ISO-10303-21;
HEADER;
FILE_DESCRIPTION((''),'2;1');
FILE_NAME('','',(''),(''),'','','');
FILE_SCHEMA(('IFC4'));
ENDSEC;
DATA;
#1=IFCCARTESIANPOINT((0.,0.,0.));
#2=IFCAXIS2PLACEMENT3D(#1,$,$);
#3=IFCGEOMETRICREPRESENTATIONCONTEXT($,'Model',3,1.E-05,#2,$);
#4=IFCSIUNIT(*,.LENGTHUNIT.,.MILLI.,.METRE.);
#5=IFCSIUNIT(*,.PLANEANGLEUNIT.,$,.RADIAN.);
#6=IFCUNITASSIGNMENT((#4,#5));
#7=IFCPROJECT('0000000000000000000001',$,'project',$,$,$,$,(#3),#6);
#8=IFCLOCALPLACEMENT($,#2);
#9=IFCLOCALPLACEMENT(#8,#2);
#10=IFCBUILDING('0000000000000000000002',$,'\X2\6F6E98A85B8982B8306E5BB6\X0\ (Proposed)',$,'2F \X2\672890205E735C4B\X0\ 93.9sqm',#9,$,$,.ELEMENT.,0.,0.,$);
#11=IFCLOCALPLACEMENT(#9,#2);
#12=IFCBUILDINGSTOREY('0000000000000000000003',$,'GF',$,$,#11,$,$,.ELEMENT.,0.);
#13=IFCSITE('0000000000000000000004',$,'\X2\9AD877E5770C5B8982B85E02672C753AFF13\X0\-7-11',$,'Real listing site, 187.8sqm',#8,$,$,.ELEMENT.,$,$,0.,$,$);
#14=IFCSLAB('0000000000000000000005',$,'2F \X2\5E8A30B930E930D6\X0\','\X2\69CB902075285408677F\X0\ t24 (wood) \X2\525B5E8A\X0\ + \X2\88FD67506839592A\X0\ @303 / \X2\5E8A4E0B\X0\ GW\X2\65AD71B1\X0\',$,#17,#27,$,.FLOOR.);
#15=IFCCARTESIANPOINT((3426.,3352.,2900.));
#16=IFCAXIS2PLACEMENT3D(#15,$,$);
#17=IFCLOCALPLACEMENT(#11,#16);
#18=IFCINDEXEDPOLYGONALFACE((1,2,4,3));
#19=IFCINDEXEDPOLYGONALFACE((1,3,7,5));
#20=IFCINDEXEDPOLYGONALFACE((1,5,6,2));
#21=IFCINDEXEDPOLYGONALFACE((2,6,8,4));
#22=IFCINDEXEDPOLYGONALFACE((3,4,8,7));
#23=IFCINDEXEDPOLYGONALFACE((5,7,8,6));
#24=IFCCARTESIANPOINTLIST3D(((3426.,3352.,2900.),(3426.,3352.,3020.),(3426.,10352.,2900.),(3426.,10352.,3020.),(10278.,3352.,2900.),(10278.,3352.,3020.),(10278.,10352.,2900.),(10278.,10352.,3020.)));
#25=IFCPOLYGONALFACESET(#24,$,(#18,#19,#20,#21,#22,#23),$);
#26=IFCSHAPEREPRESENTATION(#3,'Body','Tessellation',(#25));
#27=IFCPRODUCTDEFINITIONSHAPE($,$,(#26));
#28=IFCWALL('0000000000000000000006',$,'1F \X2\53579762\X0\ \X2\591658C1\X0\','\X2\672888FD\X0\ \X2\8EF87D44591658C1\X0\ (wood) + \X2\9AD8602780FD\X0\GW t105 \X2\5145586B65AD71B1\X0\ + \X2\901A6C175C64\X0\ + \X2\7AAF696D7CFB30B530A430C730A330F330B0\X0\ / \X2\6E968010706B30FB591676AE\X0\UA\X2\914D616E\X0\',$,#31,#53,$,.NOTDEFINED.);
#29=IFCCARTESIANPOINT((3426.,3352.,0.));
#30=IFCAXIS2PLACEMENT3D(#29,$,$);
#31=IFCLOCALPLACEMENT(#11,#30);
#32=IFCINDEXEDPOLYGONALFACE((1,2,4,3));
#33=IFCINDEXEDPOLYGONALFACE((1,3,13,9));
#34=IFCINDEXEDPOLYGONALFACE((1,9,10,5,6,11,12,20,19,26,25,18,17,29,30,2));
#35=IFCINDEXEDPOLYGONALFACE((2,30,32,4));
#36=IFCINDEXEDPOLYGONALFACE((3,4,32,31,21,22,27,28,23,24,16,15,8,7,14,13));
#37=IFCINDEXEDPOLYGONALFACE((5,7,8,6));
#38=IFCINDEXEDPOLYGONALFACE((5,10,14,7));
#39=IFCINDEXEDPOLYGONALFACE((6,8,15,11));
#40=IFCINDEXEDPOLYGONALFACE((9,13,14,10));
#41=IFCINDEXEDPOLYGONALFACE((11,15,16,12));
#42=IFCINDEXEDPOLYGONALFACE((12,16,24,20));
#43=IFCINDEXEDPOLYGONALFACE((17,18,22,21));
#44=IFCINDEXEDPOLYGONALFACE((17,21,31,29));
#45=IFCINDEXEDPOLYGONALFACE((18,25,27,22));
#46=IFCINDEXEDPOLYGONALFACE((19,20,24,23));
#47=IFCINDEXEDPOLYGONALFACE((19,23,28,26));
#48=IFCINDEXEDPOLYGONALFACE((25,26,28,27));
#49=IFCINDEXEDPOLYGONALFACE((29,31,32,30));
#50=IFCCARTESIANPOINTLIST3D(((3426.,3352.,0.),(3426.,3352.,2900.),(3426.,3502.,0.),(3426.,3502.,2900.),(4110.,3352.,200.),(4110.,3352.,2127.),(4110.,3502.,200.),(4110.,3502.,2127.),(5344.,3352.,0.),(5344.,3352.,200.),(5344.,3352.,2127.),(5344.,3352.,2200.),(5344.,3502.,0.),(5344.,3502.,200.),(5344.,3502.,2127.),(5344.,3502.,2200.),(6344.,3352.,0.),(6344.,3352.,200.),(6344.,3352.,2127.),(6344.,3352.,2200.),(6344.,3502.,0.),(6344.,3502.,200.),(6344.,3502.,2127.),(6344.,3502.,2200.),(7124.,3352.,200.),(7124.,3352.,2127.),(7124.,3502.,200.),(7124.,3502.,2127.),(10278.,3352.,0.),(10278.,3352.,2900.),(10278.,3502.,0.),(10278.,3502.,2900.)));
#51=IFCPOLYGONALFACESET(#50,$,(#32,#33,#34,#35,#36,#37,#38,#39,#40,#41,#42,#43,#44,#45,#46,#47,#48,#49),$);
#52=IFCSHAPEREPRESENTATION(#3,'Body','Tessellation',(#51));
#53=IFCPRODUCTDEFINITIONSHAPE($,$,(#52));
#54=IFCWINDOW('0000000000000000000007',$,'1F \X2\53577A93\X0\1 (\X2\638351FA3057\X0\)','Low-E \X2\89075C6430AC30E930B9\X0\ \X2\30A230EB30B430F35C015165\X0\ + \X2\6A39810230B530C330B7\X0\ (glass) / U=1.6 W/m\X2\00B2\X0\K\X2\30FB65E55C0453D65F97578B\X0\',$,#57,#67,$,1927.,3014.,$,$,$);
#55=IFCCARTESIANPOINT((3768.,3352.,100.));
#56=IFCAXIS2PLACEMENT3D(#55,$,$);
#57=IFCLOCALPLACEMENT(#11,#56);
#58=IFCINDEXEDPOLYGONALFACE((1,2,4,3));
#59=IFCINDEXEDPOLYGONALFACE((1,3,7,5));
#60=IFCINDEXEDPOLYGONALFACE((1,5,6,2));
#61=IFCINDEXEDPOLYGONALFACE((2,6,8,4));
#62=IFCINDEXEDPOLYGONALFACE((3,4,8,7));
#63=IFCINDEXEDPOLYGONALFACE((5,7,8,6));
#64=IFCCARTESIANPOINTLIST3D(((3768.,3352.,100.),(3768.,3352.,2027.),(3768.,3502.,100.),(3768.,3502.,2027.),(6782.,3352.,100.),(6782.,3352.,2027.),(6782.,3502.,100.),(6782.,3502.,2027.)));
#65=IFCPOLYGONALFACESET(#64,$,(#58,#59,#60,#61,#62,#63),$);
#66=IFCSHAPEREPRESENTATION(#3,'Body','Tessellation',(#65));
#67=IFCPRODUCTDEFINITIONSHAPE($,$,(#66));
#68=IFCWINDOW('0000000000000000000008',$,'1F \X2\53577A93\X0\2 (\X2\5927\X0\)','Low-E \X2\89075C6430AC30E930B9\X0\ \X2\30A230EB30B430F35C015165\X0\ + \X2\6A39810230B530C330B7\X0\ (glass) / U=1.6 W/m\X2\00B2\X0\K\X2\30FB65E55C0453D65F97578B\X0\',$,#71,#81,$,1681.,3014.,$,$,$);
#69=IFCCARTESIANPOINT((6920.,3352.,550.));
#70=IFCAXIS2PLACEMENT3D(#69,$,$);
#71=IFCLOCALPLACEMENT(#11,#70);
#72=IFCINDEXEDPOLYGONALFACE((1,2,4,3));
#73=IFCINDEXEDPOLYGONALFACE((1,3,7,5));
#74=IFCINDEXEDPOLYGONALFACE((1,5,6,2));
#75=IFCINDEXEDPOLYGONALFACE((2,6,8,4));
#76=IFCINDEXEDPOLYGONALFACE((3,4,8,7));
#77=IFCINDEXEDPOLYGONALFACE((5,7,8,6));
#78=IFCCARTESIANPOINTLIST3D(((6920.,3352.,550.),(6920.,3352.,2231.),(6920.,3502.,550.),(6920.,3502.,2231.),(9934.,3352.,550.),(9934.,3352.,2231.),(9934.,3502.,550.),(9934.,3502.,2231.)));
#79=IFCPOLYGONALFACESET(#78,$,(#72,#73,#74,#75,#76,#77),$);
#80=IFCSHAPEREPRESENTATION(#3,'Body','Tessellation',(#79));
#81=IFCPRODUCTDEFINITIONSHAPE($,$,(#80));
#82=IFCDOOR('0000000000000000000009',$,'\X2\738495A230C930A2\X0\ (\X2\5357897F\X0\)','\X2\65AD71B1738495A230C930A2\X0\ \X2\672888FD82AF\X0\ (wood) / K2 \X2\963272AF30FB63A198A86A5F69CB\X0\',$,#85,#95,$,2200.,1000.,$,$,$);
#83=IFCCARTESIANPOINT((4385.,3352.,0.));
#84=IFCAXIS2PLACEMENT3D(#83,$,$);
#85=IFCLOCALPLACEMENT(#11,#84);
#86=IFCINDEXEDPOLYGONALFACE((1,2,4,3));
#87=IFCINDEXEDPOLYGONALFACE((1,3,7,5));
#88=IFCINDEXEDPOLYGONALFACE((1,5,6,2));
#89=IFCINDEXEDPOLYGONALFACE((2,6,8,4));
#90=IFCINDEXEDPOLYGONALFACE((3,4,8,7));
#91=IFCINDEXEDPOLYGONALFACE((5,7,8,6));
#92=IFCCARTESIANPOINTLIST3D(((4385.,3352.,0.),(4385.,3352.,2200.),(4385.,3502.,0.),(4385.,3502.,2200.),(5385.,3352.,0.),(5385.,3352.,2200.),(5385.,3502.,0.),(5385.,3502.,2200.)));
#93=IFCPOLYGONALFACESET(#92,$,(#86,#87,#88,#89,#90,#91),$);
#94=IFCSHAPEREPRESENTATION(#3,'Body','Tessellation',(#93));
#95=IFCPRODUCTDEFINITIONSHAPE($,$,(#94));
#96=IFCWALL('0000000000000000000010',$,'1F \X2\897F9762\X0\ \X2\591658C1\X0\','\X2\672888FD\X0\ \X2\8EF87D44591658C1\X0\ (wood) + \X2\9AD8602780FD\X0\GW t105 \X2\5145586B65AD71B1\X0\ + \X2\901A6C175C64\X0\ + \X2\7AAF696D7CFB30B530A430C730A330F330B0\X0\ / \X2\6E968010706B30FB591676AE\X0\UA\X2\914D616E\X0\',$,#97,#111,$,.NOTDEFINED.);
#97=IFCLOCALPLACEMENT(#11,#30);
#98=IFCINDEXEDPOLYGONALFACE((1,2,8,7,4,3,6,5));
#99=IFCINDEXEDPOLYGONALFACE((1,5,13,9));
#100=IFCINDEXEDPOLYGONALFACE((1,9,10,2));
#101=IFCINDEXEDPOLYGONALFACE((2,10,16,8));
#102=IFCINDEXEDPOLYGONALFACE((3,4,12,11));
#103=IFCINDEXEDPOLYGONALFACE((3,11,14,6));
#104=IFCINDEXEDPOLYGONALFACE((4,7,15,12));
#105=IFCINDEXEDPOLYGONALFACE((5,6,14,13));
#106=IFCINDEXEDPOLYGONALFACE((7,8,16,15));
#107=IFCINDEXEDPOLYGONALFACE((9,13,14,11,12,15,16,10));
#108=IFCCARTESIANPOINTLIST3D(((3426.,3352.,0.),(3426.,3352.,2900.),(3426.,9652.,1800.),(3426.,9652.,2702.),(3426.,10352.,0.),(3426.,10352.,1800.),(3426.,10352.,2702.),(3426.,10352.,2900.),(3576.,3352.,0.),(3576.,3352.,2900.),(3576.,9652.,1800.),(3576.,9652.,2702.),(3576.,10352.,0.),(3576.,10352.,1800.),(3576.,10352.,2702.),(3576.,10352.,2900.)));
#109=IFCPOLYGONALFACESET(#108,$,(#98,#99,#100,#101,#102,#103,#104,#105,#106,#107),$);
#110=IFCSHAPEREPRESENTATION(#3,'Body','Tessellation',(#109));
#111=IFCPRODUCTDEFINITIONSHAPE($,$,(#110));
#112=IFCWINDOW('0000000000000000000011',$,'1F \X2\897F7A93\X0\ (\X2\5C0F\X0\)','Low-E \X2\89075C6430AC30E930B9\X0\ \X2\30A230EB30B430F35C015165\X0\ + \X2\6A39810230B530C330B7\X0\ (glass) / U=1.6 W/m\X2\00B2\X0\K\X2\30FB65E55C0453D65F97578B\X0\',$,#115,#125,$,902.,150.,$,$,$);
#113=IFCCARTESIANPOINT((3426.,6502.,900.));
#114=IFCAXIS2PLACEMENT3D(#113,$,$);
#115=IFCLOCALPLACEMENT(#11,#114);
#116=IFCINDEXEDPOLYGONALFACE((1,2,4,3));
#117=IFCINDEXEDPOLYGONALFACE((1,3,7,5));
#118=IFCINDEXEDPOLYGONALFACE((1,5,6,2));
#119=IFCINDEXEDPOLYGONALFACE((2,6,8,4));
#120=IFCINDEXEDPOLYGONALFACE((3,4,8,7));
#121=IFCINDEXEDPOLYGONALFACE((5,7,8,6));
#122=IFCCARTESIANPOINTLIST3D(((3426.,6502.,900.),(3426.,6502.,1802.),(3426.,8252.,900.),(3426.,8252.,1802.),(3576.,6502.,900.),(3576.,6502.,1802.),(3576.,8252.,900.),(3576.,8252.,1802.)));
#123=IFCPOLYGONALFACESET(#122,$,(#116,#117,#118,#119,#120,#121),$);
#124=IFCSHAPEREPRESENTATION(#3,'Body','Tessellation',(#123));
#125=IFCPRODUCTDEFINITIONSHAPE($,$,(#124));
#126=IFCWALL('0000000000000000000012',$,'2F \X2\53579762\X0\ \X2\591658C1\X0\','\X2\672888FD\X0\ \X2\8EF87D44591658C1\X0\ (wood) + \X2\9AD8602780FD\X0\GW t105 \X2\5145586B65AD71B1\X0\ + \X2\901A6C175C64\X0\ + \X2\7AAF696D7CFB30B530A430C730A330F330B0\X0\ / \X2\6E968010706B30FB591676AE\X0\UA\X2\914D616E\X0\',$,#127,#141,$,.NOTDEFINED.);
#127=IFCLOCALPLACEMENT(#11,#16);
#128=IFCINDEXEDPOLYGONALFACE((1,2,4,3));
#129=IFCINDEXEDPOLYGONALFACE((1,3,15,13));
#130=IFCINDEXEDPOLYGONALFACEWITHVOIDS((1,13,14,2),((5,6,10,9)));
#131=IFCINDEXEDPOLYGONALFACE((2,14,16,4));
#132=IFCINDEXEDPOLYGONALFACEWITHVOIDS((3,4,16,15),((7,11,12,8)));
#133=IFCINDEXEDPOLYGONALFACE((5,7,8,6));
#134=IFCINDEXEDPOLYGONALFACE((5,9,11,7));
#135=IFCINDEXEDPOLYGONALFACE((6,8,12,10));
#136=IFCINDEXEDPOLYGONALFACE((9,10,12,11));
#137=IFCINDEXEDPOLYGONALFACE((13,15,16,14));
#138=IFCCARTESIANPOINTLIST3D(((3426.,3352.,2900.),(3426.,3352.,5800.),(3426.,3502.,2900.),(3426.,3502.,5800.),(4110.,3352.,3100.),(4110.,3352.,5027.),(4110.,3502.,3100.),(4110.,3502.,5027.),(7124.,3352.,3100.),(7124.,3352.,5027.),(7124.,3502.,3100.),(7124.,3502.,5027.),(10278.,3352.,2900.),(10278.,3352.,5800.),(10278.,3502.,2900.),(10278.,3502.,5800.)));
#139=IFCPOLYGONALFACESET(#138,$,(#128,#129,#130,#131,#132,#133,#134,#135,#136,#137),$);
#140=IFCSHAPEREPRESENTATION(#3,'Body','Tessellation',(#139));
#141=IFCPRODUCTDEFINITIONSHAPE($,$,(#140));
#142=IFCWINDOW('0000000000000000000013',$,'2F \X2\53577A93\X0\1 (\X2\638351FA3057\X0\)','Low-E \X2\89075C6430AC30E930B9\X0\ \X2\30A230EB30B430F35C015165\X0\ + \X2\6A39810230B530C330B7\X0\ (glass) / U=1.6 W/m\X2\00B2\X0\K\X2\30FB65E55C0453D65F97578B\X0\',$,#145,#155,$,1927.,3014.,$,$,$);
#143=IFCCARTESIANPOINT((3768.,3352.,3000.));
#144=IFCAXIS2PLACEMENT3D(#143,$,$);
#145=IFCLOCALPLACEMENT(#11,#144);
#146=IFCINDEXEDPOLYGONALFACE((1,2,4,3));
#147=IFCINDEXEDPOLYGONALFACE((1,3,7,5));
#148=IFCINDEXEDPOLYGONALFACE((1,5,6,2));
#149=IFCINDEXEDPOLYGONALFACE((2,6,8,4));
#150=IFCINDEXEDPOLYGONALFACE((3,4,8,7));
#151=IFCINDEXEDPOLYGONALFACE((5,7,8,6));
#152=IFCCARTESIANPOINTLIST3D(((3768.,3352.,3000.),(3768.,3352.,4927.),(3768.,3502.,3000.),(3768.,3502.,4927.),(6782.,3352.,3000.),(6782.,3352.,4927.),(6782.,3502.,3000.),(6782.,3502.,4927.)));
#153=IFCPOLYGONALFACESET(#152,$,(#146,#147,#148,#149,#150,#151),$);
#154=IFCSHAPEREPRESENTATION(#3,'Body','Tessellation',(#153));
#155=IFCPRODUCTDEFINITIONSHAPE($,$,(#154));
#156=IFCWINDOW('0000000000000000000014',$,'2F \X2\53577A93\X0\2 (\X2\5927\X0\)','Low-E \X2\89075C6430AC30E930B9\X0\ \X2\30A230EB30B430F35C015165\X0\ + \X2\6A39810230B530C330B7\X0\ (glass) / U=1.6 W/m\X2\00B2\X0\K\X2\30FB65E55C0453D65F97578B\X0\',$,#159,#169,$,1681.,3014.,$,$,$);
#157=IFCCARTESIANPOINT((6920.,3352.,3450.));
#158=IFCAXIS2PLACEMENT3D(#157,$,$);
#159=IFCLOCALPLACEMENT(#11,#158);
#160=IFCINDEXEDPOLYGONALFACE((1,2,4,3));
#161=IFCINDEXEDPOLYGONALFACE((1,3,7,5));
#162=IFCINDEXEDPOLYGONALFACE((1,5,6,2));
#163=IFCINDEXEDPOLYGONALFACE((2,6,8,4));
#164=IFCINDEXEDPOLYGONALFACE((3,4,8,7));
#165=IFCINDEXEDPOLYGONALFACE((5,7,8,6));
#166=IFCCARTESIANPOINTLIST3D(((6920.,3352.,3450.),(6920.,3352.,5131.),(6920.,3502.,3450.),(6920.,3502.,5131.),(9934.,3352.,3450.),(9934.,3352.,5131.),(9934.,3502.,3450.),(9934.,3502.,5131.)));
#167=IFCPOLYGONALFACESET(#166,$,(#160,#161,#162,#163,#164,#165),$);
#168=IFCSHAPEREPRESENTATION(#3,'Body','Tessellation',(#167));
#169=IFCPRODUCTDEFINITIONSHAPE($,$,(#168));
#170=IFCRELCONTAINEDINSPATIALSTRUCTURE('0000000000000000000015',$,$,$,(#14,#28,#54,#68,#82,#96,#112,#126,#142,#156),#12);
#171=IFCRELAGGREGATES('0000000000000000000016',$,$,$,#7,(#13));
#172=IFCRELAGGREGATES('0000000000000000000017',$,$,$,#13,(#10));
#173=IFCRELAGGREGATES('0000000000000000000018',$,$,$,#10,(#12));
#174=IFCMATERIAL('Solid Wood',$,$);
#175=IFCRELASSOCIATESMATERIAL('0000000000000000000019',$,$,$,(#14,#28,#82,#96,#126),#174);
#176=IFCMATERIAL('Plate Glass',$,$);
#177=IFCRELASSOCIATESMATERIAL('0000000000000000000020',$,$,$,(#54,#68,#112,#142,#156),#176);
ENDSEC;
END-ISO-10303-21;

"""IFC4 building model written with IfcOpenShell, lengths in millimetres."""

from ifc_helpers import new_model, si_unit, frame, frame_2d, origin, place, context, project, spatial, rectangle, extrude, material, element, fill, save


model = new_model("IFC4")

# Units and contexts
model_context = context("Model", 3, precision=1e-05, world=origin())
ifc_project = project(units=[si_unit("LENGTHUNIT", "METRE", prefix="MILLI"), si_unit("PLANEANGLEUNIT", "RADIAN")], contexts=[model_context])

# Site, building, storey
site_placement = place(None, origin())
site = spatial("IfcSite", under=ifc_project, at=site_placement, Name="高知県安芸市本町３-7-11", ObjectType="Real listing site, 187.8sqm", CompositionType="ELEMENT", RefElevation=0.0)
building_placement = place(site_placement, origin())
building = spatial("IfcBuilding", under=site, at=building_placement, Name="潮風安芸の家 (Proposed)", ObjectType="2F 木造平屋 93.9sqm", CompositionType="ELEMENT", ElevationOfRefHeight=0.0, ElevationOfTerrain=0.0)
storey_placement = place(building_placement, origin())
storey = spatial("IfcBuildingStorey", under=building, at=storey_placement, Name="GF", CompositionType="ELEMENT", Elevation=0.0)

# Slab
ifc_material_1 = material(Name="Solid Wood")
slab_1_placement = place(storey_placement, frame((3426.0, 3352.0, 2900.0)))
element("IfcSlab", 1, at=slab_1_placement, inside=storey, material=ifc_material_1, Name="2F 床スラブ", Description="構造用合板 t24 (wood) 剛床 + 製材根太 @303 / 床下 GW断熱", PredefinedType="FLOOR", context=model_context, shape_type="SweptSolid", body=[
    extrude(rectangle(XDim=6852.0, YDim=7000.0, at=frame_2d((3426.0, 3500.0))), frame((3426.0, 3352.0, 2900.0)), (0.0, 0.0, 1.0), 120.0),
])

# Wall, openings, windows, door
wall_1_placement = place(storey_placement, frame((3426.0, 3352.0, 0.0)))
wall_1 = element("IfcWall", 2, at=wall_1_placement, inside=storey, material=ifc_material_1, Name="1F 南面 外壁", Description="木製 軸組外壁 (wood) + 高性能GW t105 充填断熱 + 通気層 + 窯業系サイディング / 準耐火・外皮UA配慮", PredefinedType="NOTDEFINED", context=model_context, shape_type="SweptSolid", body=[
    extrude(rectangle(XDim=6852.0, YDim=150.0, at=frame_2d((3426.0, 75.0))), frame((3426.0, 3352.0, 0.0)), (0.0, 0.0, 1.0), 2900.0),
])
opening_1_placement = place(storey_placement, frame((3768.0, 3352.0, 100.0)))
opening_1 = element("IfcOpeningElement", 3, at=opening_1_placement, cuts=wall_1, PredefinedType="NOTDEFINED", context=model_context, shape_type="SweptSolid", body=[
    extrude(rectangle(XDim=3014.0, YDim=150.0, at=frame_2d((1507.0, 75.0))), frame((3768.0, 3352.0, 100.0)), (0.0, 0.0, 1.0), 1927.0),
])
opening_2_placement = place(storey_placement, frame((6920.0, 3352.0, 550.0)))
opening_2 = element("IfcOpeningElement", 4, at=opening_2_placement, cuts=wall_1, PredefinedType="NOTDEFINED", context=model_context, shape_type="SweptSolid", body=[
    extrude(rectangle(XDim=3014.0, YDim=150.0, at=frame_2d((1507.0, 75.0))), frame((6920.0, 3352.0, 550.0)), (0.0, 0.0, 1.0), 1681.0),
])
opening_3_placement = place(storey_placement, frame((4385.0, 3352.0, 0.0)))
opening_3 = element("IfcOpeningElement", 5, at=opening_3_placement, cuts=wall_1, PredefinedType="NOTDEFINED", context=model_context, shape_type="SweptSolid", body=[
    extrude(rectangle(XDim=1000.0, YDim=150.0, at=frame_2d((500.0, 75.0))), frame((4385.0, 3352.0, 0.0)), (0.0, 0.0, 1.0), 2200.0),
])
ifc_material_2 = material(Name="Plate Glass")
window_1_placement = place(storey_placement, frame((3768.0, 3352.0, 100.0)))
window_1 = element("IfcWindow", 6, at=window_1_placement, inside=storey, material=ifc_material_2, Name="1F 南窓1 (掃出し)", Description="Low-E 複層ガラス アルゴン封入 + 樹脂サッシ (glass) / U=1.6 W/m²K・日射取得型", OverallHeight=1927.0, OverallWidth=3014.0, context=model_context, shape_type="SweptSolid", body=[
    extrude(rectangle(XDim=3014.0, YDim=150.0, at=frame_2d((1507.0, 75.0))), frame((3768.0, 3352.0, 100.0)), (0.0, 0.0, 1.0), 1927.0),
])
fill(opening_1, window_1)
window_2_placement = place(storey_placement, frame((6920.0, 3352.0, 550.0)))
window_2 = element("IfcWindow", 7, at=window_2_placement, inside=storey, material=ifc_material_2, Name="1F 南窓2 (大)", Description="Low-E 複層ガラス アルゴン封入 + 樹脂サッシ (glass) / U=1.6 W/m²K・日射取得型", OverallHeight=1681.0, OverallWidth=3014.0, context=model_context, shape_type="SweptSolid", body=[
    extrude(rectangle(XDim=3014.0, YDim=150.0, at=frame_2d((1507.0, 75.0))), frame((6920.0, 3352.0, 550.0)), (0.0, 0.0, 1.0), 1681.0),
])
fill(opening_2, window_2)
door_placement = place(storey_placement, frame((4385.0, 3352.0, 0.0)))
door = element("IfcDoor", 8, at=door_placement, inside=storey, material=ifc_material_1, Name="玄関ドア (南西)", Description="断熱玄関ドア 木製芯 (wood) / K2 防犯・採風機構", OverallHeight=2200.0, OverallWidth=1000.0, context=model_context, shape_type="SweptSolid", body=[
    extrude(rectangle(XDim=1000.0, YDim=150.0, at=frame_2d((500.0, 75.0))), frame((4385.0, 3352.0, 0.0)), (0.0, 0.0, 1.0), 2200.0),
])
fill(opening_3, door)

# Wall, opening, window
wall_2_placement = place(storey_placement, frame((3426.0, 3352.0, 0.0)))
wall_2 = element("IfcWall", 9, at=wall_2_placement, inside=storey, material=ifc_material_1, Name="1F 西面 外壁", Description="木製 軸組外壁 (wood) + 高性能GW t105 充填断熱 + 通気層 + 窯業系サイディング / 準耐火・外皮UA配慮", PredefinedType="NOTDEFINED", context=model_context, shape_type="SweptSolid", body=[
    extrude(rectangle(XDim=150.0, YDim=7000.0, at=frame_2d((75.0, 3500.0))), frame((3426.0, 3352.0, 0.0)), (0.0, 0.0, 1.0), 2900.0),
])
opening_4_placement = place(storey_placement, frame((3426.0, 6502.0, 900.0)))
opening_4 = element("IfcOpeningElement", 10, at=opening_4_placement, cuts=wall_2, PredefinedType="NOTDEFINED", context=model_context, shape_type="SweptSolid", body=[
    extrude(rectangle(XDim=150.0, YDim=1750.0, at=frame_2d((75.0, 875.0))), frame((3426.0, 6502.0, 900.0)), (0.0, 0.0, 1.0), 902.0),
])
window_3_placement = place(storey_placement, frame((3426.0, 6502.0, 900.0)))
window_3 = element("IfcWindow", 11, at=window_3_placement, inside=storey, material=ifc_material_2, Name="1F 西窓 (小)", Description="Low-E 複層ガラス アルゴン封入 + 樹脂サッシ (glass) / U=1.6 W/m²K・日射取得型", OverallHeight=902.0, OverallWidth=150.0, context=model_context, shape_type="SweptSolid", body=[
    extrude(rectangle(XDim=150.0, YDim=1750.0, at=frame_2d((75.0, 875.0))), frame((3426.0, 6502.0, 900.0)), (0.0, 0.0, 1.0), 902.0),
])
fill(opening_4, window_3)

# Wall, openings, windows
wall_3_placement = place(storey_placement, frame((3426.0, 3352.0, 2900.0)))
wall_3 = element("IfcWall", 12, at=wall_3_placement, inside=storey, material=ifc_material_1, Name="2F 南面 外壁", Description="木製 軸組外壁 (wood) + 高性能GW t105 充填断熱 + 通気層 + 窯業系サイディング / 準耐火・外皮UA配慮", PredefinedType="NOTDEFINED", context=model_context, shape_type="SweptSolid", body=[
    extrude(rectangle(XDim=6852.0, YDim=150.0, at=frame_2d((3426.0, 75.0))), frame((3426.0, 3352.0, 2900.0)), (0.0, 0.0, 1.0), 2900.0),
])
opening_5_placement = place(storey_placement, frame((3768.0, 3352.0, 3000.0)))
opening_5 = element("IfcOpeningElement", 13, at=opening_5_placement, cuts=wall_3, PredefinedType="NOTDEFINED", context=model_context, shape_type="SweptSolid", body=[
    extrude(rectangle(XDim=3014.0, YDim=150.0, at=frame_2d((1507.0, 75.0))), frame((3768.0, 3352.0, 3000.0)), (0.0, 0.0, 1.0), 1927.0),
])
opening_6_placement = place(storey_placement, frame((6920.0, 3352.0, 3450.0)))
opening_6 = element("IfcOpeningElement", 14, at=opening_6_placement, cuts=wall_3, PredefinedType="NOTDEFINED", context=model_context, shape_type="SweptSolid", body=[
    extrude(rectangle(XDim=3014.0, YDim=150.0, at=frame_2d((1507.0, 75.0))), frame((6920.0, 3352.0, 3450.0)), (0.0, 0.0, 1.0), 1681.0),
])
window_4_placement = place(storey_placement, frame((3768.0, 3352.0, 3000.0)))
window_4 = element("IfcWindow", 15, at=window_4_placement, inside=storey, material=ifc_material_2, Name="2F 南窓1 (掃出し)", Description="Low-E 複層ガラス アルゴン封入 + 樹脂サッシ (glass) / U=1.6 W/m²K・日射取得型", OverallHeight=1927.0, OverallWidth=3014.0, context=model_context, shape_type="SweptSolid", body=[
    extrude(rectangle(XDim=3014.0, YDim=150.0, at=frame_2d((1507.0, 75.0))), frame((3768.0, 3352.0, 3000.0)), (0.0, 0.0, 1.0), 1927.0),
])
fill(opening_5, window_4)
window_5_placement = place(storey_placement, frame((6920.0, 3352.0, 3450.0)))
window_5 = element("IfcWindow", 16, at=window_5_placement, inside=storey, material=ifc_material_2, Name="2F 南窓2 (大)", Description="Low-E 複層ガラス アルゴン封入 + 樹脂サッシ (glass) / U=1.6 W/m²K・日射取得型", OverallHeight=1681.0, OverallWidth=3014.0, context=model_context, shape_type="SweptSolid", body=[
    extrude(rectangle(XDim=3014.0, YDim=150.0, at=frame_2d((1507.0, 75.0))), frame((6920.0, 3352.0, 3450.0)), (0.0, 0.0, 1.0), 1681.0),
])
fill(opening_6, window_5)

save(model, "model.ifc")
